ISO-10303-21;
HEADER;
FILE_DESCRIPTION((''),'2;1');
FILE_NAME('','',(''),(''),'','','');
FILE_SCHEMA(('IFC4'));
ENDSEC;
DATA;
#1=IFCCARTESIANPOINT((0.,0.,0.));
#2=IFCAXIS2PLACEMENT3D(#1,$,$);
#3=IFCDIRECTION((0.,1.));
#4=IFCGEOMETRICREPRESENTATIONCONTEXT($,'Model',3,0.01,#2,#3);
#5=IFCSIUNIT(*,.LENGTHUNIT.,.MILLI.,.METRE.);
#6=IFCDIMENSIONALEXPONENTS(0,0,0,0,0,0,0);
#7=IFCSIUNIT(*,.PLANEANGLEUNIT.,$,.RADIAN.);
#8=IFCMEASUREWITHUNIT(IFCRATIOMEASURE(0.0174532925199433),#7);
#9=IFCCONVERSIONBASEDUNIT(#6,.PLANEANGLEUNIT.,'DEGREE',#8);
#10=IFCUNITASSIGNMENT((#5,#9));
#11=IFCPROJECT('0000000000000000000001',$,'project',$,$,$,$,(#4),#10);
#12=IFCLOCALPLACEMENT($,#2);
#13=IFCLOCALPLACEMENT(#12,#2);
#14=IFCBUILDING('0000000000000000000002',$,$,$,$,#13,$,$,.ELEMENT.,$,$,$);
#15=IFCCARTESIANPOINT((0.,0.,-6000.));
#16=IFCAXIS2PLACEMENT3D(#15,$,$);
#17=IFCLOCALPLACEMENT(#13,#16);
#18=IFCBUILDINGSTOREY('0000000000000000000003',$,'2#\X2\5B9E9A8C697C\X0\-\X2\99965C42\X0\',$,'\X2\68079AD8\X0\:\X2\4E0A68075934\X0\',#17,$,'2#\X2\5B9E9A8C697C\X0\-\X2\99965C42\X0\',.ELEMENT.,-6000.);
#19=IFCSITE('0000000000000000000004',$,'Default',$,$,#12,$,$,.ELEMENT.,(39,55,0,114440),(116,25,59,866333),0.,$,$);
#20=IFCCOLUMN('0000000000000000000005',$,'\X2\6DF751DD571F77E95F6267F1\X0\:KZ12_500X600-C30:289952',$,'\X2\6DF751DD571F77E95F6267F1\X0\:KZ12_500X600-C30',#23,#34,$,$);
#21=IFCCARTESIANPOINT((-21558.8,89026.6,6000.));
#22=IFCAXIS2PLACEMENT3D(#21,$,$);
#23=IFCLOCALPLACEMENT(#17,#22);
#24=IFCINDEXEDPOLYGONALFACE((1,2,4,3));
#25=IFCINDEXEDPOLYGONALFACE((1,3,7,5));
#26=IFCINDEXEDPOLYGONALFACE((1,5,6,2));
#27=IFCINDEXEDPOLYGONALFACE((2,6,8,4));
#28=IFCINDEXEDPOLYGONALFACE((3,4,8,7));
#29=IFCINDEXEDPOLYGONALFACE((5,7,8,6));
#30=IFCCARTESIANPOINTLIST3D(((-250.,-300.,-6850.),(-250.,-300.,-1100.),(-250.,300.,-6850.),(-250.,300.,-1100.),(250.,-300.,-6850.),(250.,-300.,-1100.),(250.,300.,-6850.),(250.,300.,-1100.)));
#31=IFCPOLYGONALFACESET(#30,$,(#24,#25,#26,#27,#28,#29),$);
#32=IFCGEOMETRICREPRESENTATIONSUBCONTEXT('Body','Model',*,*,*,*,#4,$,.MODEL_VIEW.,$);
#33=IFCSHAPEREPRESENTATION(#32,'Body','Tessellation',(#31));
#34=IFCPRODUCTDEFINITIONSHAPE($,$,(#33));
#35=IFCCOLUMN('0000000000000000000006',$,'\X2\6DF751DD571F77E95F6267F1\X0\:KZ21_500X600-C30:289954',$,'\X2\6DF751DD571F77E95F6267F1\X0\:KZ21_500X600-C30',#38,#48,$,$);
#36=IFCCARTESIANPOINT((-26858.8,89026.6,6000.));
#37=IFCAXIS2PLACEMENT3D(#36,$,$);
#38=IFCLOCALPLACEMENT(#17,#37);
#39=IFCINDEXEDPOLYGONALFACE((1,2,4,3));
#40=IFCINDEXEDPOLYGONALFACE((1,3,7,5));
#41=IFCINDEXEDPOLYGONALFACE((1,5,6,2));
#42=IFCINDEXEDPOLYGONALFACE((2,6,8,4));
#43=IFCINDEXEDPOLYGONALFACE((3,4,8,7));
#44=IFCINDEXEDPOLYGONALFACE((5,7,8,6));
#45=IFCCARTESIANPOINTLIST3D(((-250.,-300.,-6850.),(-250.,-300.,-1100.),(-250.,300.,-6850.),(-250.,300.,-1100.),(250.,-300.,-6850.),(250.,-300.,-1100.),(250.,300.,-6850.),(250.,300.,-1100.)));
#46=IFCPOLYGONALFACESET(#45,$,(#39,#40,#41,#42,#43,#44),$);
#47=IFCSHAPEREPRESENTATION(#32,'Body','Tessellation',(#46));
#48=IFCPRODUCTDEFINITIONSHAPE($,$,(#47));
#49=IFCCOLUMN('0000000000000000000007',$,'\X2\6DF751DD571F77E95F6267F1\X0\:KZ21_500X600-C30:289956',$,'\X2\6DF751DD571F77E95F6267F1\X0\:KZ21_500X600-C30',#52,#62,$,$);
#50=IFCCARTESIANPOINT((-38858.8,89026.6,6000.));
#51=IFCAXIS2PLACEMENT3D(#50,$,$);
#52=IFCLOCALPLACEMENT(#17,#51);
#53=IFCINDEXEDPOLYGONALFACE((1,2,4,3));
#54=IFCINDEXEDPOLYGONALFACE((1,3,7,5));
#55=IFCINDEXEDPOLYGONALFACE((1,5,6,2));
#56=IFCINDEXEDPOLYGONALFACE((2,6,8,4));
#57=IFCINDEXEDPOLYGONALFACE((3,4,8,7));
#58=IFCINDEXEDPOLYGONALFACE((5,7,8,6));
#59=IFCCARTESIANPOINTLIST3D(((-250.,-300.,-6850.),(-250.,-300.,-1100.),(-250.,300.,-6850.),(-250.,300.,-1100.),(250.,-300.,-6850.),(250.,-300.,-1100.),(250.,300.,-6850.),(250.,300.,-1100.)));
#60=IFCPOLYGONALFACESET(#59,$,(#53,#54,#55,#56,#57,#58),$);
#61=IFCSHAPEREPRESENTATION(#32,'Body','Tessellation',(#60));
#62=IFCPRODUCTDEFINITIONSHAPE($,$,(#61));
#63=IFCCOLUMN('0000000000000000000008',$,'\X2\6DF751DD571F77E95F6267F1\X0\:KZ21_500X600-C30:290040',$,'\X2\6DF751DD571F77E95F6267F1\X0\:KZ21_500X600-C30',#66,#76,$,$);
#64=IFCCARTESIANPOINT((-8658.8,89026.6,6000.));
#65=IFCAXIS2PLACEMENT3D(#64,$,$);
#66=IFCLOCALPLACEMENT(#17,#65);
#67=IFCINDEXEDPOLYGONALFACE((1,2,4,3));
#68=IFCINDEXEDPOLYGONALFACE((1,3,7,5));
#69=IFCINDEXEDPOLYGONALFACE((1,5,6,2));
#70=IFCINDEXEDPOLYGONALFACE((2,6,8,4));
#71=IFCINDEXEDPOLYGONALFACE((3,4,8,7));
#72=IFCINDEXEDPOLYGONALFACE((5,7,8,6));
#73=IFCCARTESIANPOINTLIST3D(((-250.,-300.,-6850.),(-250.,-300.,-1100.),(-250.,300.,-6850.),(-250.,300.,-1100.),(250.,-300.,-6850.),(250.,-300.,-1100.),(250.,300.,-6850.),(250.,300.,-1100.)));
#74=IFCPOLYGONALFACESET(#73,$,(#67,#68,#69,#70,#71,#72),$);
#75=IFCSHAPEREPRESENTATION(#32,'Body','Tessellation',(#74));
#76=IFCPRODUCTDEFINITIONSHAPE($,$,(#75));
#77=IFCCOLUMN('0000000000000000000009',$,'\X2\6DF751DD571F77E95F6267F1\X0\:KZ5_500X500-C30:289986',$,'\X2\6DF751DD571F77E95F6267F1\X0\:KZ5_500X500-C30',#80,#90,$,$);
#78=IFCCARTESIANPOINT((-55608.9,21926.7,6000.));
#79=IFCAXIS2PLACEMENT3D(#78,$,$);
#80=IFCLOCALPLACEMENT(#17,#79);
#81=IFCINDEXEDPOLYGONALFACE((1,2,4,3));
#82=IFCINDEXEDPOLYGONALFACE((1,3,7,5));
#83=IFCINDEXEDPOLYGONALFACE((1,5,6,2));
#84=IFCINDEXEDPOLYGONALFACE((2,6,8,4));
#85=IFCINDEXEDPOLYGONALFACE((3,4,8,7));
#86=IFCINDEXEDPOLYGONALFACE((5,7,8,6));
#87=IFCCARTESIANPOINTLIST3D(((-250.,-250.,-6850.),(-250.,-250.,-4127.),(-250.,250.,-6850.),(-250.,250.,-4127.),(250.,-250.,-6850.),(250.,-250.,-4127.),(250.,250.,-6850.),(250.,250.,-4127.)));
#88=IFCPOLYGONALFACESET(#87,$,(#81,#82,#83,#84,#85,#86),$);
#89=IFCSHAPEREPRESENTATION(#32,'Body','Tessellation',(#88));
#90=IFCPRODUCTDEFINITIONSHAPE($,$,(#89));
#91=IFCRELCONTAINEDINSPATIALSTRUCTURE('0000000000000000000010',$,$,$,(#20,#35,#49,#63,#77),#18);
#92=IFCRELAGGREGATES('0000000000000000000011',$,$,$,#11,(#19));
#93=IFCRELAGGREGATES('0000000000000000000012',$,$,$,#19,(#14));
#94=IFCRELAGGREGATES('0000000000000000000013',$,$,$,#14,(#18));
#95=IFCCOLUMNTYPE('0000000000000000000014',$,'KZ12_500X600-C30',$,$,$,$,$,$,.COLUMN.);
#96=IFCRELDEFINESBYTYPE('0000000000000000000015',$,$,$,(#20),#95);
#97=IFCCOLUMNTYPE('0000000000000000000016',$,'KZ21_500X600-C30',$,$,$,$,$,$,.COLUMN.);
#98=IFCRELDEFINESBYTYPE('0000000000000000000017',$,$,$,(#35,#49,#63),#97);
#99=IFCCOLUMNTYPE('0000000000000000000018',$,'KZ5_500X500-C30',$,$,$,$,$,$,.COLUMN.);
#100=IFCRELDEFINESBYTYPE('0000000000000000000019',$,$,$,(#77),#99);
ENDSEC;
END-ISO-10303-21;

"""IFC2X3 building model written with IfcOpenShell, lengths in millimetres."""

from ifc_helpers import new_model, entity, si_unit, converted_unit, direction, frame, origin, origin_2d_with_axis, place, context, subcontext, project, spatial, rectangle, extrude, source, transform, mapped, type_object, type_shapes, element, save


model = new_model("IFC2X3")

# Units and contexts
model_context = context("Model", 3, precision=0.01, world=origin(), true_north=direction((0.0, 1.0)))
body_context = subcontext(model_context, "Body", "Model", "MODEL_VIEW")
ifc_project = project(units=[si_unit("LENGTHUNIT", "METRE", prefix="MILLI"), converted_unit("PLANEANGLEUNIT", "DEGREE", entity("IfcRatioMeasure", 0.0174532925199433), si_unit("PLANEANGLEUNIT", "RADIAN"), dimensions=[0, 0, 0, 0, 0, 0, 0])], contexts=[model_context])

# Site, building, storey
site_placement = place(None, origin())
site = spatial("IfcSite", under=ifc_project, at=site_placement, Name="Default", CompositionType="ELEMENT", RefLatitude=(39, 55, 0, 114440), RefLongitude=(116, 25, 59, 866333), RefElevation=0.0)
building_placement = place(site_placement, origin())
building = spatial("IfcBuilding", under=site, at=building_placement, CompositionType="ELEMENT")
storey_placement = place(building_placement, frame((0.0, 0.0, -6000.0)))
storey = spatial("IfcBuildingStorey", under=building, at=storey_placement, Name="2#实验楼-首层", ObjectType="标高:上标头", LongName="2#实验楼-首层", CompositionType="ELEMENT", Elevation=-6000.0)

# Columns
column_type_1 = type_object("IfcColumnType", Name="KZ12_500X600-C30", PredefinedType="COLUMN")
shared_shape_1 = source(origin(), body_context, "Body", "SweptSolid", [
    extrude(rectangle(XDim=600.0, YDim=500.0, at=origin_2d_with_axis()), frame((0.0, 0.0, -6850.0), z_axis=(0.0, 0.0, 1.0), x_axis=(0.0, -1.0, 0.0)), (0.0, 0.0, 1.0), 5750.0),
])
type_shapes(column_type_1, [shared_shape_1])
column_1_placement = place(storey_placement, frame((-21558.8, 89026.6, 6000.0)))
element("IfcColumn", 1, at=column_1_placement, inside=storey, type_object=column_type_1, Name="混凝土矩形柱:KZ12_500X600-C30:289952", ObjectType="混凝土矩形柱:KZ12_500X600-C30", context=body_context, shape_type="MappedRepresentation", body=[
    mapped(shared_shape_1, transform((0.0, 0.0, 0.0), scale=1.0)),
])
column_type_2 = type_object("IfcColumnType", Name="KZ21_500X600-C30", PredefinedType="COLUMN")
shared_shape_2 = source(origin(), body_context, "Body", "SweptSolid", [
    extrude(rectangle(XDim=600.0, YDim=500.0, at=origin_2d_with_axis()), frame((0.0, 0.0, -6850.0), z_axis=(0.0, 0.0, 1.0), x_axis=(0.0, -1.0, 0.0)), (0.0, 0.0, 1.0), 5750.0),
])
type_shapes(column_type_2, [shared_shape_2])
for number, where, name in (
    (2, (-26858.8, 89026.6, 6000.0), "混凝土矩形柱:KZ21_500X600-C30:289954"),
    (3, (-38858.8, 89026.6, 6000.0), "混凝土矩形柱:KZ21_500X600-C30:289956"),
    (4, (-8658.8, 89026.6, 6000.0), "混凝土矩形柱:KZ21_500X600-C30:290040"),
):
    element("IfcColumn", number, at=place(storey_placement, frame(where)), inside=storey, type_object=column_type_2, Name=name, ObjectType="混凝土矩形柱:KZ21_500X600-C30", context=body_context, shape_type="MappedRepresentation", body=[
        mapped(shared_shape_2, transform((0.0, 0.0, 0.0), scale=1.0)),
    ])
column_type_3 = type_object("IfcColumnType", Name="KZ5_500X500-C30", PredefinedType="COLUMN")
shared_shape_3 = source(origin(), body_context, "Body", "SweptSolid", [
    extrude(rectangle(XDim=500.0, YDim=500.0, at=origin_2d_with_axis()), frame((0.0, 0.0, -6850.0), z_axis=(0.0, 0.0, 1.0), x_axis=(0.0, -1.0, 0.0)), (0.0, 0.0, 1.0), 2723.0),
])
type_shapes(column_type_3, [shared_shape_3])
column_2_placement = place(storey_placement, frame((-55608.9, 21926.7, 6000.0)))
element("IfcColumn", 5, at=column_2_placement, inside=storey, type_object=column_type_3, Name="混凝土矩形柱:KZ5_500X500-C30:289986", ObjectType="混凝土矩形柱:KZ5_500X500-C30", context=body_context, shape_type="MappedRepresentation", body=[
    mapped(shared_shape_3, transform((0.0, 0.0, 0.0), scale=1.0)),
])

save(model, "model.ifc")
